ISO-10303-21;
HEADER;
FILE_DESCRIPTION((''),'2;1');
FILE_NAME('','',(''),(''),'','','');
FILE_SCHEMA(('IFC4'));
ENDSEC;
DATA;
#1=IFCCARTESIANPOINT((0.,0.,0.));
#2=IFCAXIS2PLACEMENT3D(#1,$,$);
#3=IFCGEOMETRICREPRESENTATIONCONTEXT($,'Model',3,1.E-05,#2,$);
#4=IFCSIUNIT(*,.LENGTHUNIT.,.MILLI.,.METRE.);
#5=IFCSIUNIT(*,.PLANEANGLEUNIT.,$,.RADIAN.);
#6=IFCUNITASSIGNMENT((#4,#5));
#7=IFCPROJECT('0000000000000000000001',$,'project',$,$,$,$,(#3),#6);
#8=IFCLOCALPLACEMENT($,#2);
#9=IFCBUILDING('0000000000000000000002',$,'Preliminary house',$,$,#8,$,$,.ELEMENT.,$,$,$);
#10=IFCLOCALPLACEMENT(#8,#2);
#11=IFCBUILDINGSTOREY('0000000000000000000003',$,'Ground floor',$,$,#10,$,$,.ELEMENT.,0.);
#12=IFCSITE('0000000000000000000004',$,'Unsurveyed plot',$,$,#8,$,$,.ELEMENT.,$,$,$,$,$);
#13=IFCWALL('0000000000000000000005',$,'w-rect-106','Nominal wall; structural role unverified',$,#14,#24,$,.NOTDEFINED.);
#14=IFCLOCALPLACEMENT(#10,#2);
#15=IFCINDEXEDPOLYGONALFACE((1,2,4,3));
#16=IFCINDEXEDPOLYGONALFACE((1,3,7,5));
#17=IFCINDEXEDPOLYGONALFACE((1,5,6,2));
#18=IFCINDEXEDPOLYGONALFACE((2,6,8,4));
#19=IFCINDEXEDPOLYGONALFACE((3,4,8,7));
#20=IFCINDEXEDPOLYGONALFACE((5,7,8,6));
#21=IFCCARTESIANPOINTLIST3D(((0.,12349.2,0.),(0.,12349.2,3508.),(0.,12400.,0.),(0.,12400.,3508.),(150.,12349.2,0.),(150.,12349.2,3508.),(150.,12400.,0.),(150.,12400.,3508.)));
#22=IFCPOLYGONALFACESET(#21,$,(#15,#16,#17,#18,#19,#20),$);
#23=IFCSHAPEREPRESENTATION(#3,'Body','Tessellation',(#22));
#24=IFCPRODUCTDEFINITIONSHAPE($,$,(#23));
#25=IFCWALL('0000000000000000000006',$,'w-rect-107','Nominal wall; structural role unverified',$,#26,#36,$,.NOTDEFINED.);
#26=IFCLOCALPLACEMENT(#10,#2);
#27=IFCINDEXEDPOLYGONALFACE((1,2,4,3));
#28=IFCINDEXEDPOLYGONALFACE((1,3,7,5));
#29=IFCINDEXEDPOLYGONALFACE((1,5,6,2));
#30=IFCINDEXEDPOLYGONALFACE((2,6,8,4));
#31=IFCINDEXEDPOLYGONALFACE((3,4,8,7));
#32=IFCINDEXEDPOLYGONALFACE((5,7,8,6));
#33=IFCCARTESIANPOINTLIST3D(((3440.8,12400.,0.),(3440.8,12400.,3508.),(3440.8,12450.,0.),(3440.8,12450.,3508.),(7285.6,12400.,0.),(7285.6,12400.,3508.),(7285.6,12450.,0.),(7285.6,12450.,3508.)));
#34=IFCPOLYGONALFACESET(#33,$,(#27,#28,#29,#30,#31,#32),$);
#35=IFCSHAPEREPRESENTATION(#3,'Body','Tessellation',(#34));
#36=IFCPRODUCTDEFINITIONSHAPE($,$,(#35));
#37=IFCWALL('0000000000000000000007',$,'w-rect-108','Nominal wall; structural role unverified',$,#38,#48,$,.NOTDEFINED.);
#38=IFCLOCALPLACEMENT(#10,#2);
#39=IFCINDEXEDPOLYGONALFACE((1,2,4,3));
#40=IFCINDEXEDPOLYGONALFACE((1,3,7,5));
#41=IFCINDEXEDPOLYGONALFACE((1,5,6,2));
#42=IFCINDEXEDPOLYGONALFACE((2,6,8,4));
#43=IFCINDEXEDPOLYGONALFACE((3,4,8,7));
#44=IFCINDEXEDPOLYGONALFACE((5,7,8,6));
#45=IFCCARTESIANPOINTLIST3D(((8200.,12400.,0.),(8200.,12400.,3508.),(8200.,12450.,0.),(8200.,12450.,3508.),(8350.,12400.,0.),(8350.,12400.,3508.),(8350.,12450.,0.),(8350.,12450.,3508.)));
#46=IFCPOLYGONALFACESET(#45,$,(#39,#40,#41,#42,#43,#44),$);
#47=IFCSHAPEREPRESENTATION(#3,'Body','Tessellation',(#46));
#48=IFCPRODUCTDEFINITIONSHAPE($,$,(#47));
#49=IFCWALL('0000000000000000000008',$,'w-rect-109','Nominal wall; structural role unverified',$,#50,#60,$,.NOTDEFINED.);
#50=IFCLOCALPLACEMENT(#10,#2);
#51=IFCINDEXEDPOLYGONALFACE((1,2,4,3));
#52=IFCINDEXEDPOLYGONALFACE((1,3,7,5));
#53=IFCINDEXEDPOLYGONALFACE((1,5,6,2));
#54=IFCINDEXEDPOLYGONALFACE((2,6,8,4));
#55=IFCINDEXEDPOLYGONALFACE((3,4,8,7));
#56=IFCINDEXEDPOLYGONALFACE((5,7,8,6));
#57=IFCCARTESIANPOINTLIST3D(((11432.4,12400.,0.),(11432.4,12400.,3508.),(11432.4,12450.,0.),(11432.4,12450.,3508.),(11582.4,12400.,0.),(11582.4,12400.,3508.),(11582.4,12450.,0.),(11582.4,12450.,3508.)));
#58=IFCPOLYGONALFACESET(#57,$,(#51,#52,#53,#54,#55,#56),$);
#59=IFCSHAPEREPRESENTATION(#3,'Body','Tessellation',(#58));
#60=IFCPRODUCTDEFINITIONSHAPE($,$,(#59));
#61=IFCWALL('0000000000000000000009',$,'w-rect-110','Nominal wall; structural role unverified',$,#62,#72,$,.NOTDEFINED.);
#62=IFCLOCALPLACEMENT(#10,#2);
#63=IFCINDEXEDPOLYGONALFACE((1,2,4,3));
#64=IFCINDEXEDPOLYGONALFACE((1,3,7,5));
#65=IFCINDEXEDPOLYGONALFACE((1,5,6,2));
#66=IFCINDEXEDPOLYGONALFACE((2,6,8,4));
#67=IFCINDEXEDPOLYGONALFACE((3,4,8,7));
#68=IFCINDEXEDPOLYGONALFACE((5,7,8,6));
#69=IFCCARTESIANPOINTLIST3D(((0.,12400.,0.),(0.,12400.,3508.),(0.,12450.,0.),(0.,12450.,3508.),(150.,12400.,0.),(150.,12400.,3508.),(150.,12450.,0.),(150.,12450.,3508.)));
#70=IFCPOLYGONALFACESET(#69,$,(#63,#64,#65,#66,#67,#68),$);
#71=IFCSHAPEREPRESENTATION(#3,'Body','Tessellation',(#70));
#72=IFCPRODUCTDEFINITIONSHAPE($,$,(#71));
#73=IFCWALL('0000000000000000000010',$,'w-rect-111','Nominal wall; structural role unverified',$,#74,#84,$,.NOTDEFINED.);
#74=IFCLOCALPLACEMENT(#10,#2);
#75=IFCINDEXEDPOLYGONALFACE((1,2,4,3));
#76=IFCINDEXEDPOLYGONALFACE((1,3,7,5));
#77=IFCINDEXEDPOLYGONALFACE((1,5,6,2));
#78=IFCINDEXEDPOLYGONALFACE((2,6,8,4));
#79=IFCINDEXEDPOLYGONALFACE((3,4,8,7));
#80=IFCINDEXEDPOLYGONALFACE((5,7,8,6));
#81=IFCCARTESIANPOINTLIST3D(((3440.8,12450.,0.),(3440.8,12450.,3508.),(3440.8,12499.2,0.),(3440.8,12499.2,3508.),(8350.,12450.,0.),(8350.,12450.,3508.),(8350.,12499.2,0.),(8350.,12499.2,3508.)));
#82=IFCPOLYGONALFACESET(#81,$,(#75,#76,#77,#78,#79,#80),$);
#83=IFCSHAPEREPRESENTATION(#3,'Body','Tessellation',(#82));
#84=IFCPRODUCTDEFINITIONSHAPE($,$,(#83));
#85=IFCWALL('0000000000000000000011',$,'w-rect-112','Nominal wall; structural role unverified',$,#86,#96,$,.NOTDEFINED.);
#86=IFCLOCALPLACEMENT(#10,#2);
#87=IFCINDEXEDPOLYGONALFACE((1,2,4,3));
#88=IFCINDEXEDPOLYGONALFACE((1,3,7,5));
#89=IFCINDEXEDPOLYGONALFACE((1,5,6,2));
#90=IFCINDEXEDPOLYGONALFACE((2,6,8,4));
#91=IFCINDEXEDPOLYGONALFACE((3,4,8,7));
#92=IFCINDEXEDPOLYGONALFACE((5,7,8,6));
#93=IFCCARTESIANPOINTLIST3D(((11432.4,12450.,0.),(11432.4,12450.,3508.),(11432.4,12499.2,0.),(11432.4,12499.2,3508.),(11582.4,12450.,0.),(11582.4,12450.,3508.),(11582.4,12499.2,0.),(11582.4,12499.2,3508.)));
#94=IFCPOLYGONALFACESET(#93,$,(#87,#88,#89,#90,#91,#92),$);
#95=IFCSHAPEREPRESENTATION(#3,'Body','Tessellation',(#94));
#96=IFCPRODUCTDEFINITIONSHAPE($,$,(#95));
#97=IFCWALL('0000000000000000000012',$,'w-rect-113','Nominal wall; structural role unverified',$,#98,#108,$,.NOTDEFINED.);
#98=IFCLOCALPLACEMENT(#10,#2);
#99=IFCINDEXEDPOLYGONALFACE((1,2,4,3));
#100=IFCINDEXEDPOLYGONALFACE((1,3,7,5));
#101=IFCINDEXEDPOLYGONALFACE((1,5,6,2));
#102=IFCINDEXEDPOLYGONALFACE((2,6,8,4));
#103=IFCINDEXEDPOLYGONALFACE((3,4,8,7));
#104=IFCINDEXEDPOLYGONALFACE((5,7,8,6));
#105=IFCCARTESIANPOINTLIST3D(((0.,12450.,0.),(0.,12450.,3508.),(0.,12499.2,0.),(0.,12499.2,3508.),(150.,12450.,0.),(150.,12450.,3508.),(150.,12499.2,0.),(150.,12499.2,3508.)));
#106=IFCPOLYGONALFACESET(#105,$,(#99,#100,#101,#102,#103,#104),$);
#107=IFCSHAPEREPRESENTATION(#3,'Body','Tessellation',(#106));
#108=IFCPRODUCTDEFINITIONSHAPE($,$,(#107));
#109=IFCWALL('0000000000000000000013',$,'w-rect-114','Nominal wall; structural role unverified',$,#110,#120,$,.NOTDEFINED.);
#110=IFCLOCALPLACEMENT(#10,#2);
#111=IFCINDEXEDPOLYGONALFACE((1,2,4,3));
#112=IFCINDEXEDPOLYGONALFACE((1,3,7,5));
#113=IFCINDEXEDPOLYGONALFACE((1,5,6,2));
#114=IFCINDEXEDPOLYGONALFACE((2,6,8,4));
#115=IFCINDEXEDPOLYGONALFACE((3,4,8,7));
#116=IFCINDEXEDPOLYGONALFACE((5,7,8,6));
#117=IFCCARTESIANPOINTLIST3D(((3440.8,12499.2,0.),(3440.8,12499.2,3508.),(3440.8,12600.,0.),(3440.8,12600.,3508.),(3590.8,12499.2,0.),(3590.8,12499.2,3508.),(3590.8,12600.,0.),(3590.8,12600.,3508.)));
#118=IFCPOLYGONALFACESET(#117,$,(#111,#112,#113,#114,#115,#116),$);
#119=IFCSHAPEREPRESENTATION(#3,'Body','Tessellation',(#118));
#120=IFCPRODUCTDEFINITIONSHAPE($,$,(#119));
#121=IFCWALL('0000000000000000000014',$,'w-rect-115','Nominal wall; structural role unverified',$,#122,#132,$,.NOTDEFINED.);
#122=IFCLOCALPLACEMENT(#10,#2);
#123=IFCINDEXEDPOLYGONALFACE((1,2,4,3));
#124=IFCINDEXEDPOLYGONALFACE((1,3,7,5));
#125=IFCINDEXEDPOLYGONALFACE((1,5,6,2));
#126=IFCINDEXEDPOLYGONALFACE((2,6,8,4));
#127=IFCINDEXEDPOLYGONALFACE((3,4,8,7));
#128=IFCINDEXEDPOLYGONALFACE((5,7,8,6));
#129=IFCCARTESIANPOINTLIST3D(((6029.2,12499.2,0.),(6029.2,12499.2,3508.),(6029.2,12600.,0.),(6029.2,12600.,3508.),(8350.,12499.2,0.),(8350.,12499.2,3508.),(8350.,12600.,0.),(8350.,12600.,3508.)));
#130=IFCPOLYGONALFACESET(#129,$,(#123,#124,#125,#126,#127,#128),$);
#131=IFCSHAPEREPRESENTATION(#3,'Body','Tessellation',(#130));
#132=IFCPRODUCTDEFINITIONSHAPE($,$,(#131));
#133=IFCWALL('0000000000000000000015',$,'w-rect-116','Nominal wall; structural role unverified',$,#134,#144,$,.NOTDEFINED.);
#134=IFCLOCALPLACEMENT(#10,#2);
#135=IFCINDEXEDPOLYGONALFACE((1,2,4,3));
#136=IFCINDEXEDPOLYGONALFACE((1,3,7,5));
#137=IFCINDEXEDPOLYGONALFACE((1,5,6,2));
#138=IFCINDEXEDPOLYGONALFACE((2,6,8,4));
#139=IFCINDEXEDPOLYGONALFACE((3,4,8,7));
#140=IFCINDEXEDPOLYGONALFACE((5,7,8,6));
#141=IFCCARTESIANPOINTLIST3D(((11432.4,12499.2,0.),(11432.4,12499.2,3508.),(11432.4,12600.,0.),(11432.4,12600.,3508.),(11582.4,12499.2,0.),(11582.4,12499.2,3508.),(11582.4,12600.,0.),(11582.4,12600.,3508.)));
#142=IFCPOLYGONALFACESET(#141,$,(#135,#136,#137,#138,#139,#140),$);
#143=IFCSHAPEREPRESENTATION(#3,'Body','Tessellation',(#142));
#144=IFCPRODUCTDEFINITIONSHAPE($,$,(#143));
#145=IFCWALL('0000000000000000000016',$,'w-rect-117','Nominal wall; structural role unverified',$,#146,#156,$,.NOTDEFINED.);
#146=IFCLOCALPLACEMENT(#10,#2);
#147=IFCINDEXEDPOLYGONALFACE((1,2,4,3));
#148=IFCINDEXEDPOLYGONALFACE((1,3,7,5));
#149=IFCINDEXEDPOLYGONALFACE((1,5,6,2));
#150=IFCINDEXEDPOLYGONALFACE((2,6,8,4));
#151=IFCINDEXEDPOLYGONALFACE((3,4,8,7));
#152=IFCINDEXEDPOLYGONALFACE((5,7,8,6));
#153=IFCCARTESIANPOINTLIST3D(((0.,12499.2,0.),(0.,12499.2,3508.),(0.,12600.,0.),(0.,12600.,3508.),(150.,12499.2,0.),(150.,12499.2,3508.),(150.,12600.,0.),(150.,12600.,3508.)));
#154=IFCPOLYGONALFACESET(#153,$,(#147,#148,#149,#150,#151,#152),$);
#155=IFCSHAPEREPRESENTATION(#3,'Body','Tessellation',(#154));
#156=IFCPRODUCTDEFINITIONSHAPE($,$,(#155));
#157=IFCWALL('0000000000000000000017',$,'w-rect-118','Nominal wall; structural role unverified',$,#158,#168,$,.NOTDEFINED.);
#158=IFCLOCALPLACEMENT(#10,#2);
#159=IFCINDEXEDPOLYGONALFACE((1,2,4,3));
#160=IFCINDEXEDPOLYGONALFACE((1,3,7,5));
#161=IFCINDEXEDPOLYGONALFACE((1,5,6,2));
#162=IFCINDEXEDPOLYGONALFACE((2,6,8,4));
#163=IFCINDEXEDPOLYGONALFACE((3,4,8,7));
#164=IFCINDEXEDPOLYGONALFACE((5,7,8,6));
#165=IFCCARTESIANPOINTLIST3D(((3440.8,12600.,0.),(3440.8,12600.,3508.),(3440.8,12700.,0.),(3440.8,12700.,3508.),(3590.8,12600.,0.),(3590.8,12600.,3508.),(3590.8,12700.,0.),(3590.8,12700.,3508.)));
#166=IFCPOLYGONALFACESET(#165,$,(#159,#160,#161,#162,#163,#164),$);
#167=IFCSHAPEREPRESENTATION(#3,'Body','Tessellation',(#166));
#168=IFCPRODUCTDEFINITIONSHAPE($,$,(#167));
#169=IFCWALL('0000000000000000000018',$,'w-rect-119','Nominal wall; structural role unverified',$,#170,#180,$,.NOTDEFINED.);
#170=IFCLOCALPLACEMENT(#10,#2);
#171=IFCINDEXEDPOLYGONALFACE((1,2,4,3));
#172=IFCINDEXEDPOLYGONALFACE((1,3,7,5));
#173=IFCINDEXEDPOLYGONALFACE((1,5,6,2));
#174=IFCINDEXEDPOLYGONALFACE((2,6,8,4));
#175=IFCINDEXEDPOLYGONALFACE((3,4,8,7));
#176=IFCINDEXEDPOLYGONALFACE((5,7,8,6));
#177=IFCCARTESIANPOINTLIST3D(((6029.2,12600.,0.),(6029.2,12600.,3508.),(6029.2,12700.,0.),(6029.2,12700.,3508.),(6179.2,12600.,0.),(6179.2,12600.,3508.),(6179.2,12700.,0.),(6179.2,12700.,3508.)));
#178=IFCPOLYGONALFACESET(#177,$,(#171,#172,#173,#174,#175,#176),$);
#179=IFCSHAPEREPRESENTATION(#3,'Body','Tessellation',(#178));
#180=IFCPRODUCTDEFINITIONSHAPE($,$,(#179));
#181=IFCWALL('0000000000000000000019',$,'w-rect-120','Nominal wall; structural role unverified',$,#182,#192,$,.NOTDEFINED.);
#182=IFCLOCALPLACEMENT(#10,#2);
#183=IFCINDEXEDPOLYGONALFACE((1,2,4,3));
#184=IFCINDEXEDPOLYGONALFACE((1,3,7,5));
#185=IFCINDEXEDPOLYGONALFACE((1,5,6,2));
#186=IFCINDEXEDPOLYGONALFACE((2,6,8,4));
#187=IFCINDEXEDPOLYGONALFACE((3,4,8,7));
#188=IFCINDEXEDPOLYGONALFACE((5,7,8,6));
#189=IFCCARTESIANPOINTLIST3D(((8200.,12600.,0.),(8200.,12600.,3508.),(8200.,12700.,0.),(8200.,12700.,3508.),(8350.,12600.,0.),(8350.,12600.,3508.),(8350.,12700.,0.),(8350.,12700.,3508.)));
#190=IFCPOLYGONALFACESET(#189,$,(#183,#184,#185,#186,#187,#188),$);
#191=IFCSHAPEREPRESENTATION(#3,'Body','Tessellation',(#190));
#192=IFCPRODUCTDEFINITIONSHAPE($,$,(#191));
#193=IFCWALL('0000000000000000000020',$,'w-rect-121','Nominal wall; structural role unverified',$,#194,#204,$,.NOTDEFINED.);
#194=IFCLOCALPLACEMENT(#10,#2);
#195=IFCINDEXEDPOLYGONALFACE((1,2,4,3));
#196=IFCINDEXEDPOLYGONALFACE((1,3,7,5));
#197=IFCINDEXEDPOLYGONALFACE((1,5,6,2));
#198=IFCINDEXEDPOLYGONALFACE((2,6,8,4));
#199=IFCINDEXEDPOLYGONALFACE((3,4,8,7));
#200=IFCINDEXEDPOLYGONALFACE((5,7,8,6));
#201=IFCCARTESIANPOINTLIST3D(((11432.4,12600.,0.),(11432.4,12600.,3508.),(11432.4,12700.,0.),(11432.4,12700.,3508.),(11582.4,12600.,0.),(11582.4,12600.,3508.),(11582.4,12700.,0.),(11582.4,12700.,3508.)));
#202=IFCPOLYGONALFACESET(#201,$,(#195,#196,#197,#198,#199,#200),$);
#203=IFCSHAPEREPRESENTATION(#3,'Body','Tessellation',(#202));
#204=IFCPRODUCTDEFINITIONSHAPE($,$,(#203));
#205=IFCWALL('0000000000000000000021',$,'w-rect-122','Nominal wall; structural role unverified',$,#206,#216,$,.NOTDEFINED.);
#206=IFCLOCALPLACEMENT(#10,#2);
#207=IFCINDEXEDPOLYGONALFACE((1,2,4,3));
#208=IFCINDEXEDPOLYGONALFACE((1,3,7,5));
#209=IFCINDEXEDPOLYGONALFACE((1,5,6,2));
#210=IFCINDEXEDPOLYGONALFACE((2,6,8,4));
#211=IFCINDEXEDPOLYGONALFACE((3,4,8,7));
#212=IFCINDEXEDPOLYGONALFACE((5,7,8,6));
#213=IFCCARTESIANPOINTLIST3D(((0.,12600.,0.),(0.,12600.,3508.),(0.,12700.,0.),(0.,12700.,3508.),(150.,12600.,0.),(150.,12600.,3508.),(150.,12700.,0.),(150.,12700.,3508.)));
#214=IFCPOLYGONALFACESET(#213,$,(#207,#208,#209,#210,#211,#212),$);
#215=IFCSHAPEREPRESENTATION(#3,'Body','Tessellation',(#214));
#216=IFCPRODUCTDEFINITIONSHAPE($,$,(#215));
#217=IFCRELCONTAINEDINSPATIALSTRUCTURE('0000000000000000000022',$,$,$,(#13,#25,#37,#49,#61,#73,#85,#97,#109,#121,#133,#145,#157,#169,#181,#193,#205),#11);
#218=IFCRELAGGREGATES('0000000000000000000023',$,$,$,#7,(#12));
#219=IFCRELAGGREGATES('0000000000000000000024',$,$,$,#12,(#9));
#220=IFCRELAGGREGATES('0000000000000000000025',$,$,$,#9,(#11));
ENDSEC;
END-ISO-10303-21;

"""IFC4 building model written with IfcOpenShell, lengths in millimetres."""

from ifc_helpers import new_model, si_unit, origin, place, context, project, spatial, polyline, outline, extrude, element, save


model = new_model("IFC4")

# Units and contexts
model_context = context("Model", 3, precision=1e-05, world=origin())
ifc_project = project(units=[si_unit("LENGTHUNIT", "METRE", prefix="MILLI"), si_unit("PLANEANGLEUNIT", "RADIAN")], contexts=[model_context])

# Site, building, storey
placement_1 = place(None, origin())
site = spatial("IfcSite", under=ifc_project, at=placement_1, Name="Unsurveyed plot", CompositionType="ELEMENT")
building = spatial("IfcBuilding", under=site, at=placement_1, Name="Preliminary house", CompositionType="ELEMENT")
placement_2 = place(placement_1, origin())
storey = spatial("IfcBuildingStorey", under=building, at=placement_2, Name="Ground floor", CompositionType="ELEMENT", Elevation=0.0)

# Walls
element("IfcWall", 1, at=placement_2, inside=storey, Name="w-rect-106", Description="Nominal wall; structural role unverified", PredefinedType="NOTDEFINED", context=model_context, shape_type="SweptSolid", body=[
    extrude(outline(polyline([(0.0, 12349.2), (150.0, 12349.2), (150.0, 12400.0), (0.0, 12400.0), (0.0, 12349.2)])), origin(), (0.0, 0.0, 1.0), 3508.0),
])
element("IfcWall", 2, at=placement_2, inside=storey, Name="w-rect-107", Description="Nominal wall; structural role unverified", PredefinedType="NOTDEFINED", context=model_context, shape_type="SweptSolid", body=[
    extrude(outline(polyline([(3440.8, 12400.0), (7285.6, 12400.0), (7285.6, 12450.0), (3440.8, 12450.0), (3440.8, 12400.0)])), origin(), (0.0, 0.0, 1.0), 3508.0),
])
element("IfcWall", 3, at=placement_2, inside=storey, Name="w-rect-108", Description="Nominal wall; structural role unverified", PredefinedType="NOTDEFINED", context=model_context, shape_type="SweptSolid", body=[
    extrude(outline(polyline([(8200.0, 12400.0), (8350.0, 12400.0), (8350.0, 12450.0), (8200.0, 12450.0), (8200.0, 12400.0)])), origin(), (0.0, 0.0, 1.0), 3508.0),
])
element("IfcWall", 4, at=placement_2, inside=storey, Name="w-rect-109", Description="Nominal wall; structural role unverified", PredefinedType="NOTDEFINED", context=model_context, shape_type="SweptSolid", body=[
    extrude(outline(polyline([(11432.4, 12400.0), (11582.4, 12400.0), (11582.4, 12450.0), (11432.4, 12450.0), (11432.4, 12400.0)])), origin(), (0.0, 0.0, 1.0), 3508.0),
])
element("IfcWall", 5, at=placement_2, inside=storey, Name="w-rect-110", Description="Nominal wall; structural role unverified", PredefinedType="NOTDEFINED", context=model_context, shape_type="SweptSolid", body=[
    extrude(outline(polyline([(0.0, 12400.0), (150.0, 12400.0), (150.0, 12450.0), (0.0, 12450.0), (0.0, 12400.0)])), origin(), (0.0, 0.0, 1.0), 3508.0),
])
element("IfcWall", 6, at=placement_2, inside=storey, Name="w-rect-111", Description="Nominal wall; structural role unverified", PredefinedType="NOTDEFINED", context=model_context, shape_type="SweptSolid", body=[
    extrude(outline(polyline([(3440.8, 12450.0), (8350.0, 12450.0), (8350.0, 12499.2), (3440.8, 12499.2), (3440.8, 12450.0)])), origin(), (0.0, 0.0, 1.0), 3508.0),
])
element("IfcWall", 7, at=placement_2, inside=storey, Name="w-rect-112", Description="Nominal wall; structural role unverified", PredefinedType="NOTDEFINED", context=model_context, shape_type="SweptSolid", body=[
    extrude(outline(polyline([(11432.4, 12450.0), (11582.4, 12450.0), (11582.4, 12499.2), (11432.4, 12499.2), (11432.4, 12450.0)])), origin(), (0.0, 0.0, 1.0), 3508.0),
])
element("IfcWall", 8, at=placement_2, inside=storey, Name="w-rect-113", Description="Nominal wall; structural role unverified", PredefinedType="NOTDEFINED", context=model_context, shape_type="SweptSolid", body=[
    extrude(outline(polyline([(0.0, 12450.0), (150.0, 12450.0), (150.0, 12499.2), (0.0, 12499.2), (0.0, 12450.0)])), origin(), (0.0, 0.0, 1.0), 3508.0),
])
element("IfcWall", 9, at=placement_2, inside=storey, Name="w-rect-114", Description="Nominal wall; structural role unverified", PredefinedType="NOTDEFINED", context=model_context, shape_type="SweptSolid", body=[
    extrude(outline(polyline([(3440.8, 12499.2), (3590.8, 12499.2), (3590.8, 12600.0), (3440.8, 12600.0), (3440.8, 12499.2)])), origin(), (0.0, 0.0, 1.0), 3508.0),
])
element("IfcWall", 10, at=placement_2, inside=storey, Name="w-rect-115", Description="Nominal wall; structural role unverified", PredefinedType="NOTDEFINED", context=model_context, shape_type="SweptSolid", body=[
    extrude(outline(polyline([(6029.2, 12499.2), (8350.0, 12499.2), (8350.0, 12600.0), (6029.2, 12600.0), (6029.2, 12499.2)])), origin(), (0.0, 0.0, 1.0), 3508.0),
])
element("IfcWall", 11, at=placement_2, inside=storey, Name="w-rect-116", Description="Nominal wall; structural role unverified", PredefinedType="NOTDEFINED", context=model_context, shape_type="SweptSolid", body=[
    extrude(outline(polyline([(11432.4, 12499.2), (11582.4, 12499.2), (11582.4, 12600.0), (11432.4, 12600.0), (11432.4, 12499.2)])), origin(), (0.0, 0.0, 1.0), 3508.0),
])
element("IfcWall", 12, at=placement_2, inside=storey, Name="w-rect-117", Description="Nominal wall; structural role unverified", PredefinedType="NOTDEFINED", context=model_context, shape_type="SweptSolid", body=[
    extrude(outline(polyline([(0.0, 12499.2), (150.0, 12499.2), (150.0, 12600.0), (0.0, 12600.0), (0.0, 12499.2)])), origin(), (0.0, 0.0, 1.0), 3508.0),
])
element("IfcWall", 13, at=placement_2, inside=storey, Name="w-rect-118", Description="Nominal wall; structural role unverified", PredefinedType="NOTDEFINED", context=model_context, shape_type="SweptSolid", body=[
    extrude(outline(polyline([(3440.8, 12600.0), (3590.8, 12600.0), (3590.8, 12700.0), (3440.8, 12700.0), (3440.8, 12600.0)])), origin(), (0.0, 0.0, 1.0), 3508.0),
])
element("IfcWall", 14, at=placement_2, inside=storey, Name="w-rect-119", Description="Nominal wall; structural role unverified", PredefinedType="NOTDEFINED", context=model_context, shape_type="SweptSolid", body=[
    extrude(outline(polyline([(6029.2, 12600.0), (6179.2, 12600.0), (6179.2, 12700.0), (6029.2, 12700.0), (6029.2, 12600.0)])), origin(), (0.0, 0.0, 1.0), 3508.0),
])
element("IfcWall", 15, at=placement_2, inside=storey, Name="w-rect-120", Description="Nominal wall; structural role unverified", PredefinedType="NOTDEFINED", context=model_context, shape_type="SweptSolid", body=[
    extrude(outline(polyline([(8200.0, 12600.0), (8350.0, 12600.0), (8350.0, 12700.0), (8200.0, 12700.0), (8200.0, 12600.0)])), origin(), (0.0, 0.0, 1.0), 3508.0),
])
element("IfcWall", 16, at=placement_2, inside=storey, Name="w-rect-121", Description="Nominal wall; structural role unverified", PredefinedType="NOTDEFINED", context=model_context, shape_type="SweptSolid", body=[
    extrude(outline(polyline([(11432.4, 12600.0), (11582.4, 12600.0), (11582.4, 12700.0), (11432.4, 12700.0), (11432.4, 12600.0)])), origin(), (0.0, 0.0, 1.0), 3508.0),
])
element("IfcWall", 17, at=placement_2, inside=storey, Name="w-rect-122", Description="Nominal wall; structural role unverified", PredefinedType="NOTDEFINED", context=model_context, shape_type="SweptSolid", body=[
    extrude(outline(polyline([(0.0, 12600.0), (150.0, 12600.0), (150.0, 12700.0), (0.0, 12700.0), (0.0, 12600.0)])), origin(), (0.0, 0.0, 1.0), 3508.0),
])

save(model, "model.ifc")
